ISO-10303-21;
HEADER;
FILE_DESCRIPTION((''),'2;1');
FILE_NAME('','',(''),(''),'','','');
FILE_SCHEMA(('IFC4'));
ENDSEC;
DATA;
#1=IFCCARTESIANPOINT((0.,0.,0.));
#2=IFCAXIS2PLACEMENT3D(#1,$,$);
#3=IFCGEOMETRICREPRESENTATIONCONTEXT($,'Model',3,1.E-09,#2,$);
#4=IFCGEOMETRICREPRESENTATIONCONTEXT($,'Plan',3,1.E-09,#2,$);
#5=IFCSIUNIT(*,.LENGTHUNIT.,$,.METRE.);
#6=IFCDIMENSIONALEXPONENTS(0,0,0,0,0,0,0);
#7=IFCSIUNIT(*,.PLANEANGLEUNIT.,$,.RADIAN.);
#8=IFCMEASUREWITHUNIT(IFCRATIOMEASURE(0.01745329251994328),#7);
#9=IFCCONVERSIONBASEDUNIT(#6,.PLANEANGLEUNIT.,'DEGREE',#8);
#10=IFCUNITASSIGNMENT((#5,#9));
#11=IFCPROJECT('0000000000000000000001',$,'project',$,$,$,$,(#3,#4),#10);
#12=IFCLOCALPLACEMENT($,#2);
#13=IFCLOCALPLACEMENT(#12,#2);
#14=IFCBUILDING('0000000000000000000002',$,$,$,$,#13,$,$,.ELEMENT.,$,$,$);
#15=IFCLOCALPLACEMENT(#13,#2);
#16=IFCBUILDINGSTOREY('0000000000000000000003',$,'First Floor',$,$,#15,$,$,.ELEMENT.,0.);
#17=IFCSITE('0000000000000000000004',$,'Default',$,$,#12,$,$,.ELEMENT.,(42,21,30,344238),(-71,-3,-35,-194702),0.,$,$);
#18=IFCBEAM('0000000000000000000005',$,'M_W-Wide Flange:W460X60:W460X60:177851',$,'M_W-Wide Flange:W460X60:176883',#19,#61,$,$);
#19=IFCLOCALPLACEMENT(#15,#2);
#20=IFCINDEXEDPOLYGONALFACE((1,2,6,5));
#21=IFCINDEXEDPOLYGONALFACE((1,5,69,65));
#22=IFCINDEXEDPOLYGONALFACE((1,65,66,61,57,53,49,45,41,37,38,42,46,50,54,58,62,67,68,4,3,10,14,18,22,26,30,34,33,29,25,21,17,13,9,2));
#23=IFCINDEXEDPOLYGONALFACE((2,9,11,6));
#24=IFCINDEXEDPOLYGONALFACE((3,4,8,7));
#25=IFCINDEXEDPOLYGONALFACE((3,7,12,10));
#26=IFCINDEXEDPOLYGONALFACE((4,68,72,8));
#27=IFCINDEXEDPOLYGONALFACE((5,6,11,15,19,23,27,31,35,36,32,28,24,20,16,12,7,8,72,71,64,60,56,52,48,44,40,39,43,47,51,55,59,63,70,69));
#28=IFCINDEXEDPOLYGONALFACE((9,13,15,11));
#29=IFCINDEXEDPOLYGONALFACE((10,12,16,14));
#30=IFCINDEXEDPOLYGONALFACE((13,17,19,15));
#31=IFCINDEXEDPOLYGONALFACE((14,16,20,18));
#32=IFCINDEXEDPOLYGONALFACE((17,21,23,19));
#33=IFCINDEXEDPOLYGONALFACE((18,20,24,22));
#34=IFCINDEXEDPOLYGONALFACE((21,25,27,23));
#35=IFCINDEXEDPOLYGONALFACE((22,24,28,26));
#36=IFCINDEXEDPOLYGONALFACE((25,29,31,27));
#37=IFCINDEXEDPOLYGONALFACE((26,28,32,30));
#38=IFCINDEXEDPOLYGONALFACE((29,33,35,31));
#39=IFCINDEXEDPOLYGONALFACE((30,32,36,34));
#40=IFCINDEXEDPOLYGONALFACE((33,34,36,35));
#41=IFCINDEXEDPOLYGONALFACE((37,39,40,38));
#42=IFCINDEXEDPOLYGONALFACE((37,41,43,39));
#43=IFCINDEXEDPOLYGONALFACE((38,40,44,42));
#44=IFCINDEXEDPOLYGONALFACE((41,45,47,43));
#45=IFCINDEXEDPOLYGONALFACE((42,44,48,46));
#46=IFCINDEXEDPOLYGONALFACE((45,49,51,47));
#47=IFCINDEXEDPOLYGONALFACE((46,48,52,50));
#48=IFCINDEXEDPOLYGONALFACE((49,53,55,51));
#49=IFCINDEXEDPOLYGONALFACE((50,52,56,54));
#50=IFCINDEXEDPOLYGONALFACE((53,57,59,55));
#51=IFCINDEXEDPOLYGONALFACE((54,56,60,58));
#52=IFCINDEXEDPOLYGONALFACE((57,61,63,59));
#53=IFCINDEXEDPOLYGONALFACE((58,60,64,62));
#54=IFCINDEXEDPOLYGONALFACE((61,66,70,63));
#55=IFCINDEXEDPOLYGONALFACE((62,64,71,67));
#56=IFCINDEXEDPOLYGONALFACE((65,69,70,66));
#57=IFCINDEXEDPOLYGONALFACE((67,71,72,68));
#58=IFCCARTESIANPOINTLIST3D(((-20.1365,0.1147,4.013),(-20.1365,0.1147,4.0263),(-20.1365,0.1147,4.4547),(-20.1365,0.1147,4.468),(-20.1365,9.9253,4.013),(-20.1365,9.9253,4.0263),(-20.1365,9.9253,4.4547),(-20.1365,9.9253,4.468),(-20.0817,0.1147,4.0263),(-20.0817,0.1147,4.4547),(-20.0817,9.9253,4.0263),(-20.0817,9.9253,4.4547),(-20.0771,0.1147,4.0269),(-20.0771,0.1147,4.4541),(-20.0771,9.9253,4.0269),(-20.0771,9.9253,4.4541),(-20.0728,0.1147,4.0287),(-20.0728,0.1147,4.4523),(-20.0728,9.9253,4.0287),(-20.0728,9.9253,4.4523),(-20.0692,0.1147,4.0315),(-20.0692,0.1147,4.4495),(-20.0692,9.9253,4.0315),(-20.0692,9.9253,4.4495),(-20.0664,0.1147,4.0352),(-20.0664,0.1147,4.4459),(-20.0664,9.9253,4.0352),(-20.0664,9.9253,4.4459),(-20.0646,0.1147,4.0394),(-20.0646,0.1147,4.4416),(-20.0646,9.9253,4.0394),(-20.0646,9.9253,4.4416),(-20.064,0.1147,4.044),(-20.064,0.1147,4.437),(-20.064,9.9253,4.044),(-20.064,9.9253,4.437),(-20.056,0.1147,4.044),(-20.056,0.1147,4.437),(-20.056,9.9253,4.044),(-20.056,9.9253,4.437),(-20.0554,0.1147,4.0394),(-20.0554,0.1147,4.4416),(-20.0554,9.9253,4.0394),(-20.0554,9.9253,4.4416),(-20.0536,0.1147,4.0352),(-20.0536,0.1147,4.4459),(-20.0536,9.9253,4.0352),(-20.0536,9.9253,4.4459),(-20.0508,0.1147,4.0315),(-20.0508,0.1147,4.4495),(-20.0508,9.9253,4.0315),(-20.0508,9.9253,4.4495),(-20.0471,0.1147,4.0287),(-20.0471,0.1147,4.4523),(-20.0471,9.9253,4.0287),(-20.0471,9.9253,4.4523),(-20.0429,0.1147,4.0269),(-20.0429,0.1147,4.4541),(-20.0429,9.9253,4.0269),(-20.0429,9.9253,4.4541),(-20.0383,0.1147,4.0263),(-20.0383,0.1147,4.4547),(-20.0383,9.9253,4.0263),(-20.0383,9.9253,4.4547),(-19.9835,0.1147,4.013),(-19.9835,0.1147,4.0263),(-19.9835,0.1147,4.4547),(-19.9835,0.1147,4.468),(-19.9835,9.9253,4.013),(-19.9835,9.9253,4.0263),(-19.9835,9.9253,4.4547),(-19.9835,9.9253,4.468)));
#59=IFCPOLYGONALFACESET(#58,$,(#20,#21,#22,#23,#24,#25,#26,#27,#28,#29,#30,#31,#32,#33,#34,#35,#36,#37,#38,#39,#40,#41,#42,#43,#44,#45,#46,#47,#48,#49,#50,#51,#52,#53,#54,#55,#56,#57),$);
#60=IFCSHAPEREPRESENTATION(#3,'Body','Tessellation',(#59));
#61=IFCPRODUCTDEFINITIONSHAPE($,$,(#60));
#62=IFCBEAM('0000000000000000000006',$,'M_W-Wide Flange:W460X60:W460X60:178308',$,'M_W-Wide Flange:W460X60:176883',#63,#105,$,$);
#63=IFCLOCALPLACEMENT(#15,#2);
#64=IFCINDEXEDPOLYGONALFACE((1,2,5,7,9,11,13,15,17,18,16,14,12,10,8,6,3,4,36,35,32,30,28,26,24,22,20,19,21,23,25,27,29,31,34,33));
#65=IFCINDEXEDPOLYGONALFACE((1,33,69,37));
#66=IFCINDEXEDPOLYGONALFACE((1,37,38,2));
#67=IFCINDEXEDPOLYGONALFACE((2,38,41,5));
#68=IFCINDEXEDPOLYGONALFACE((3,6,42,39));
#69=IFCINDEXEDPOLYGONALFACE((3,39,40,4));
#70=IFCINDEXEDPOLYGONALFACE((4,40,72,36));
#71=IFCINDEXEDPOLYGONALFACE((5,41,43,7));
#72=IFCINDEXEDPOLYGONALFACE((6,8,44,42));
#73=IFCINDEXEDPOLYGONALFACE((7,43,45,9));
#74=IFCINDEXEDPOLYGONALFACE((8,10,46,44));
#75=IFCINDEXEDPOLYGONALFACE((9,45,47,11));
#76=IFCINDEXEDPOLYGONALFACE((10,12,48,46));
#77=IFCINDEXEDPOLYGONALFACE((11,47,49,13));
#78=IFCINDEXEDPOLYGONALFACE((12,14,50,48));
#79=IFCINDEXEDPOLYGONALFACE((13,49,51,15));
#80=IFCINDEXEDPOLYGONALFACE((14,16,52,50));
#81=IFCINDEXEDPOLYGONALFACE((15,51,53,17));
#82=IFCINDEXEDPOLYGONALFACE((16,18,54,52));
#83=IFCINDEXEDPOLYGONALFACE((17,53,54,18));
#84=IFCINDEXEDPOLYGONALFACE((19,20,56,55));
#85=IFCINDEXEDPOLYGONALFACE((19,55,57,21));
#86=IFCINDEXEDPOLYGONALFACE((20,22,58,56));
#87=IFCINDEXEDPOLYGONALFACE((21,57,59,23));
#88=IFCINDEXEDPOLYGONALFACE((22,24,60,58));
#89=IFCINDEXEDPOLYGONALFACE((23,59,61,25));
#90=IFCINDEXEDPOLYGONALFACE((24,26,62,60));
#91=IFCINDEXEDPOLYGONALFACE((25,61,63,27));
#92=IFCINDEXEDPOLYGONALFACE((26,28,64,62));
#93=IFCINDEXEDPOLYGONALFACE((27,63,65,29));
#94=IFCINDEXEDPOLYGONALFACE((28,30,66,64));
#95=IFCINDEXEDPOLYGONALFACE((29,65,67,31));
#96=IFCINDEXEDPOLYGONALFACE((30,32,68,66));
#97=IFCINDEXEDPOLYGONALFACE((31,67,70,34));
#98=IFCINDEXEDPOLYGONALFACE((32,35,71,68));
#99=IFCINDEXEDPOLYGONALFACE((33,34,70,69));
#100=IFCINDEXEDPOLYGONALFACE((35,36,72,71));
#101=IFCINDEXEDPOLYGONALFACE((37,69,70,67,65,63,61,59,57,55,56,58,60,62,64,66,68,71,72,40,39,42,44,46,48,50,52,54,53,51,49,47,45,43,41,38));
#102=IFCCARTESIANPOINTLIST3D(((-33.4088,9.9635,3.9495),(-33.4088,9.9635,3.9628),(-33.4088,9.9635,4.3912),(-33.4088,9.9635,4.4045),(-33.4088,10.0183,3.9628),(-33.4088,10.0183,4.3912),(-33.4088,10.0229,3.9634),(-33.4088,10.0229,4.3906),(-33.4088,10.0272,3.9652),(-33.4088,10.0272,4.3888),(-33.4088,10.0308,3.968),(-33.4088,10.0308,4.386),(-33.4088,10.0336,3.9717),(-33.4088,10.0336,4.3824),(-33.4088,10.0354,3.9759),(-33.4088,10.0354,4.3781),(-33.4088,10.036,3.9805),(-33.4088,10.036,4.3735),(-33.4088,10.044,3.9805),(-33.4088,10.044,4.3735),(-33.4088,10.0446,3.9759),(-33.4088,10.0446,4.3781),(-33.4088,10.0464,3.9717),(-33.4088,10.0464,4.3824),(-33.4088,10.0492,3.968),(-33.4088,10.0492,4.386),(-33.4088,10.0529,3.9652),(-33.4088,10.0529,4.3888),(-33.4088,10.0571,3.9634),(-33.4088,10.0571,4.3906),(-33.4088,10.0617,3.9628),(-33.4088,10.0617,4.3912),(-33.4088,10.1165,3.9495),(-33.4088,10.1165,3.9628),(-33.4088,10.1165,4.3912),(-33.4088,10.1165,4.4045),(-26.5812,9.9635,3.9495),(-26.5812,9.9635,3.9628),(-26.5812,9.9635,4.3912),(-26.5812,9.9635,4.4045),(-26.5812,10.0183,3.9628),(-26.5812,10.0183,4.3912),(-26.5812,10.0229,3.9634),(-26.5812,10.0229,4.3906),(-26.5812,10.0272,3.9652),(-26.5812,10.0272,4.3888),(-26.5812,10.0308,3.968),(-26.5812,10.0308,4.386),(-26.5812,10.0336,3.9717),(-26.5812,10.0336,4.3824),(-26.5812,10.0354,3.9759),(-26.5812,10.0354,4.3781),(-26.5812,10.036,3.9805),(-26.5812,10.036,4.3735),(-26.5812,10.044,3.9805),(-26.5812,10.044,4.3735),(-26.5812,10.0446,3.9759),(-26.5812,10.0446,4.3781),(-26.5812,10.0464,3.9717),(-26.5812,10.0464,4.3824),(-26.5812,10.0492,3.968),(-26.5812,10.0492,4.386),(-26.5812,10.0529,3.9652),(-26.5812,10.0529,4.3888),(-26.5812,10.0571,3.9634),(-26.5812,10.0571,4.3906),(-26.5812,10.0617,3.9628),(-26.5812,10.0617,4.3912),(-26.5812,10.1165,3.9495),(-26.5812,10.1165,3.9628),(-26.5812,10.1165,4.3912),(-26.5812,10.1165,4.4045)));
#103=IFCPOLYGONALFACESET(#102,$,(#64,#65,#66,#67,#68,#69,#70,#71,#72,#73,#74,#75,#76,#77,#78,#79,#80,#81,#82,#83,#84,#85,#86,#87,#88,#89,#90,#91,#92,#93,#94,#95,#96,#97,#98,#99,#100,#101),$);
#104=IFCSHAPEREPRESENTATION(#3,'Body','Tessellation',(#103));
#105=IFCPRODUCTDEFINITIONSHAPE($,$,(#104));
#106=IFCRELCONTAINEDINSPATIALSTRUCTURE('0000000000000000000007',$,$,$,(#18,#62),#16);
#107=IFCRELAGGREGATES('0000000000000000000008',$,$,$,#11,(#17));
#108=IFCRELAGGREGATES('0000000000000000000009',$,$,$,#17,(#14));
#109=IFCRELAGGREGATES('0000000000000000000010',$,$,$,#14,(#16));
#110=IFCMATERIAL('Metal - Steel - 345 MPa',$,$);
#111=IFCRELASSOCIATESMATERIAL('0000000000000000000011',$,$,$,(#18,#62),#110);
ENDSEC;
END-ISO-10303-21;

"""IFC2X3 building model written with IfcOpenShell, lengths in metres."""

from ifc_helpers import new_model, entity, si_unit, converted_unit, frame, frame_2d, origin, place, context, project, spatial, polyline, circle_curve, parameter, trimmed, segment, composite_curve, outline, extrude, material, element, save


model = new_model("IFC2X3")

# Units and contexts
model_context = context("Model", 3, precision=1e-09, world=origin())
plan_context = context("Plan", 3, precision=1e-09, world=origin())
ifc_project = project(units=[si_unit("LENGTHUNIT", "METRE"), converted_unit("PLANEANGLEUNIT", "DEGREE", entity("IfcRatioMeasure", 0.01745329251994328), si_unit("PLANEANGLEUNIT", "RADIAN"), dimensions=[0, 0, 0, 0, 0, 0, 0])], contexts=[model_context, plan_context])

# Site, building, storey
site_placement = place(None, origin())
site = spatial("IfcSite", under=ifc_project, at=site_placement, Name="Default", CompositionType="ELEMENT", RefLatitude=(42, 21, 30, 344238), RefLongitude=(-71, -3, -35, -194702), RefElevation=0.0)
building_placement = place(site_placement, origin())
building = spatial("IfcBuilding", under=site, at=building_placement, CompositionType="ELEMENT")
storey_placement = place(building_placement, origin())
storey = spatial("IfcBuildingStorey", under=building, at=storey_placement, Name="First Floor", CompositionType="ELEMENT", Elevation=0.0)

# Beams
ifc_material_1 = material(Name="Metal - Steel - 345 MPa")
beam_1_placement = place(storey_placement, frame((-20.06, -0.0014, 4.468)))
element("IfcBeam", 1, at=beam_1_placement, inside=storey, material=ifc_material_1, Name="M_W-Wide Flange:W460X60:W460X60:177851", ObjectType="M_W-Wide Flange:W460X60:176883", context=model_context, shape_type="SweptSolid", body=[
    extrude(outline(composite_curve([segment(polyline([(-0.0765, -0.2142), (-0.0765, -0.2275)]), True, "CONTINUOUS"), segment(polyline([(-0.0765, -0.2275), (0.0765, -0.2275)]), True, "CONTINUOUS"), segment(polyline([(0.0765, -0.2275), (0.0765, -0.2142)]), True, "CONTINUOUS"), segment(polyline([(0.0765, -0.2142), (0.0217, -0.2142)]), True, "CONTINUOUS"), segment(trimmed(circle_curve(frame_2d((0.0217, -0.1965), x_axis=(0.0, -1.0)), 0.0177), [parameter(270.0)], [parameter(360.0)], True, "PARAMETER"), False, "CONTINUOUS"), segment(polyline([(0.004, -0.1965), (0.004, 0.1965)]), True, "CONTINUOUS"), segment(trimmed(circle_curve(frame_2d((0.0217, 0.1965), x_axis=(-1.0, 0.0)), 0.0177), [parameter(270.0)], [parameter(360.0)], True, "PARAMETER"), False, "CONTINUOUS"), segment(polyline([(0.0217, 0.2142), (0.0765, 0.2142)]), True, "CONTINUOUS"), segment(polyline([(0.0765, 0.2142), (0.0765, 0.2275)]), True, "CONTINUOUS"), segment(polyline([(0.0765, 0.2275), (-0.0765, 0.2275)]), True, "CONTINUOUS"), segment(polyline([(-0.0765, 0.2275), (-0.0765, 0.2142)]), True, "CONTINUOUS"), segment(polyline([(-0.0765, 0.2142), (-0.0217, 0.2142)]), True, "CONTINUOUS"), segment(trimmed(circle_curve(frame_2d((-0.0217, 0.1965), x_axis=(0.0, 1.0)), 0.0177), [parameter(270.0)], [parameter(360.0)], True, "PARAMETER"), False, "CONTINUOUS"), segment(polyline([(-0.004, 0.1965), (-0.004, -0.1965)]), True, "CONTINUOUS"), segment(trimmed(circle_curve(frame_2d((-0.0217, -0.1965), x_axis=(1.0, 0.0)), 0.0177), [parameter(270.0)], [parameter(0.0)], True, "PARAMETER"), False, "CONTINUOUS"), segment(polyline([(-0.0217, -0.2142), (-0.0765, -0.2142)]), True, "CONTINUOUS")], self_intersect=False)), frame((0.0, 0.1161, -0.2275), z_axis=(0.0, -1.0, 0.0), x_axis=(1.0, 0.0, 0.0)), (0.0, 0.0, -1.0), 9.8106),
])
beam_2_placement = place(storey_placement, frame((-33.5519, 10.04, 4.4045), z_axis=(0.0, 0.0, 1.0), x_axis=(0.0, -1.0, 0.0)))
element("IfcBeam", 2, at=beam_2_placement, inside=storey, material=ifc_material_1, Name="M_W-Wide Flange:W460X60:W460X60:178308", ObjectType="M_W-Wide Flange:W460X60:176883", context=model_context, shape_type="SweptSolid", body=[
    extrude(outline(composite_curve([segment(polyline([(-0.0765, -0.2142), (-0.0765, -0.2275)]), True, "CONTINUOUS"), segment(polyline([(-0.0765, -0.2275), (0.0765, -0.2275)]), True, "CONTINUOUS"), segment(polyline([(0.0765, -0.2275), (0.0765, -0.2142)]), True, "CONTINUOUS"), segment(polyline([(0.0765, -0.2142), (0.0217, -0.2142)]), True, "CONTINUOUS"), segment(trimmed(circle_curve(frame_2d((0.0217, -0.1965), x_axis=(0.0, -1.0)), 0.0177), [parameter(270.0)], [parameter(360.0)], True, "PARAMETER"), False, "CONTINUOUS"), segment(polyline([(0.004, -0.1965), (0.004, 0.1965)]), True, "CONTINUOUS"), segment(trimmed(circle_curve(frame_2d((0.0217, 0.1965), x_axis=(-1.0, 0.0)), 0.0177), [parameter(270.0)], [parameter(360.0)], True, "PARAMETER"), False, "CONTINUOUS"), segment(polyline([(0.0217, 0.2142), (0.0765, 0.2142)]), True, "CONTINUOUS"), segment(polyline([(0.0765, 0.2142), (0.0765, 0.2275)]), True, "CONTINUOUS"), segment(polyline([(0.0765, 0.2275), (-0.0765, 0.2275)]), True, "CONTINUOUS"), segment(polyline([(-0.0765, 0.2275), (-0.0765, 0.2142)]), True, "CONTINUOUS"), segment(polyline([(-0.0765, 0.2142), (-0.0217, 0.2142)]), True, "CONTINUOUS"), segment(trimmed(circle_curve(frame_2d((-0.0217, 0.1965), x_axis=(0.0, 1.0)), 0.0177), [parameter(270.0)], [parameter(360.0)], True, "PARAMETER"), False, "CONTINUOUS"), segment(polyline([(-0.004, 0.1965), (-0.004, -0.1965)]), True, "CONTINUOUS"), segment(trimmed(circle_curve(frame_2d((-0.0217, -0.1965), x_axis=(1.0, 0.0)), 0.0177), [parameter(270.0)], [parameter(0.0)], True, "PARAMETER"), False, "CONTINUOUS"), segment(polyline([(-0.0217, -0.2142), (-0.0765, -0.2142)]), True, "CONTINUOUS")], self_intersect=False)), frame((0.0, 0.1431, -0.2275), z_axis=(0.0, -1.0, 0.0), x_axis=(1.0, 0.0, 0.0)), (0.0, 0.0, -1.0), 6.8276),
])

save(model, "model.ifc")
